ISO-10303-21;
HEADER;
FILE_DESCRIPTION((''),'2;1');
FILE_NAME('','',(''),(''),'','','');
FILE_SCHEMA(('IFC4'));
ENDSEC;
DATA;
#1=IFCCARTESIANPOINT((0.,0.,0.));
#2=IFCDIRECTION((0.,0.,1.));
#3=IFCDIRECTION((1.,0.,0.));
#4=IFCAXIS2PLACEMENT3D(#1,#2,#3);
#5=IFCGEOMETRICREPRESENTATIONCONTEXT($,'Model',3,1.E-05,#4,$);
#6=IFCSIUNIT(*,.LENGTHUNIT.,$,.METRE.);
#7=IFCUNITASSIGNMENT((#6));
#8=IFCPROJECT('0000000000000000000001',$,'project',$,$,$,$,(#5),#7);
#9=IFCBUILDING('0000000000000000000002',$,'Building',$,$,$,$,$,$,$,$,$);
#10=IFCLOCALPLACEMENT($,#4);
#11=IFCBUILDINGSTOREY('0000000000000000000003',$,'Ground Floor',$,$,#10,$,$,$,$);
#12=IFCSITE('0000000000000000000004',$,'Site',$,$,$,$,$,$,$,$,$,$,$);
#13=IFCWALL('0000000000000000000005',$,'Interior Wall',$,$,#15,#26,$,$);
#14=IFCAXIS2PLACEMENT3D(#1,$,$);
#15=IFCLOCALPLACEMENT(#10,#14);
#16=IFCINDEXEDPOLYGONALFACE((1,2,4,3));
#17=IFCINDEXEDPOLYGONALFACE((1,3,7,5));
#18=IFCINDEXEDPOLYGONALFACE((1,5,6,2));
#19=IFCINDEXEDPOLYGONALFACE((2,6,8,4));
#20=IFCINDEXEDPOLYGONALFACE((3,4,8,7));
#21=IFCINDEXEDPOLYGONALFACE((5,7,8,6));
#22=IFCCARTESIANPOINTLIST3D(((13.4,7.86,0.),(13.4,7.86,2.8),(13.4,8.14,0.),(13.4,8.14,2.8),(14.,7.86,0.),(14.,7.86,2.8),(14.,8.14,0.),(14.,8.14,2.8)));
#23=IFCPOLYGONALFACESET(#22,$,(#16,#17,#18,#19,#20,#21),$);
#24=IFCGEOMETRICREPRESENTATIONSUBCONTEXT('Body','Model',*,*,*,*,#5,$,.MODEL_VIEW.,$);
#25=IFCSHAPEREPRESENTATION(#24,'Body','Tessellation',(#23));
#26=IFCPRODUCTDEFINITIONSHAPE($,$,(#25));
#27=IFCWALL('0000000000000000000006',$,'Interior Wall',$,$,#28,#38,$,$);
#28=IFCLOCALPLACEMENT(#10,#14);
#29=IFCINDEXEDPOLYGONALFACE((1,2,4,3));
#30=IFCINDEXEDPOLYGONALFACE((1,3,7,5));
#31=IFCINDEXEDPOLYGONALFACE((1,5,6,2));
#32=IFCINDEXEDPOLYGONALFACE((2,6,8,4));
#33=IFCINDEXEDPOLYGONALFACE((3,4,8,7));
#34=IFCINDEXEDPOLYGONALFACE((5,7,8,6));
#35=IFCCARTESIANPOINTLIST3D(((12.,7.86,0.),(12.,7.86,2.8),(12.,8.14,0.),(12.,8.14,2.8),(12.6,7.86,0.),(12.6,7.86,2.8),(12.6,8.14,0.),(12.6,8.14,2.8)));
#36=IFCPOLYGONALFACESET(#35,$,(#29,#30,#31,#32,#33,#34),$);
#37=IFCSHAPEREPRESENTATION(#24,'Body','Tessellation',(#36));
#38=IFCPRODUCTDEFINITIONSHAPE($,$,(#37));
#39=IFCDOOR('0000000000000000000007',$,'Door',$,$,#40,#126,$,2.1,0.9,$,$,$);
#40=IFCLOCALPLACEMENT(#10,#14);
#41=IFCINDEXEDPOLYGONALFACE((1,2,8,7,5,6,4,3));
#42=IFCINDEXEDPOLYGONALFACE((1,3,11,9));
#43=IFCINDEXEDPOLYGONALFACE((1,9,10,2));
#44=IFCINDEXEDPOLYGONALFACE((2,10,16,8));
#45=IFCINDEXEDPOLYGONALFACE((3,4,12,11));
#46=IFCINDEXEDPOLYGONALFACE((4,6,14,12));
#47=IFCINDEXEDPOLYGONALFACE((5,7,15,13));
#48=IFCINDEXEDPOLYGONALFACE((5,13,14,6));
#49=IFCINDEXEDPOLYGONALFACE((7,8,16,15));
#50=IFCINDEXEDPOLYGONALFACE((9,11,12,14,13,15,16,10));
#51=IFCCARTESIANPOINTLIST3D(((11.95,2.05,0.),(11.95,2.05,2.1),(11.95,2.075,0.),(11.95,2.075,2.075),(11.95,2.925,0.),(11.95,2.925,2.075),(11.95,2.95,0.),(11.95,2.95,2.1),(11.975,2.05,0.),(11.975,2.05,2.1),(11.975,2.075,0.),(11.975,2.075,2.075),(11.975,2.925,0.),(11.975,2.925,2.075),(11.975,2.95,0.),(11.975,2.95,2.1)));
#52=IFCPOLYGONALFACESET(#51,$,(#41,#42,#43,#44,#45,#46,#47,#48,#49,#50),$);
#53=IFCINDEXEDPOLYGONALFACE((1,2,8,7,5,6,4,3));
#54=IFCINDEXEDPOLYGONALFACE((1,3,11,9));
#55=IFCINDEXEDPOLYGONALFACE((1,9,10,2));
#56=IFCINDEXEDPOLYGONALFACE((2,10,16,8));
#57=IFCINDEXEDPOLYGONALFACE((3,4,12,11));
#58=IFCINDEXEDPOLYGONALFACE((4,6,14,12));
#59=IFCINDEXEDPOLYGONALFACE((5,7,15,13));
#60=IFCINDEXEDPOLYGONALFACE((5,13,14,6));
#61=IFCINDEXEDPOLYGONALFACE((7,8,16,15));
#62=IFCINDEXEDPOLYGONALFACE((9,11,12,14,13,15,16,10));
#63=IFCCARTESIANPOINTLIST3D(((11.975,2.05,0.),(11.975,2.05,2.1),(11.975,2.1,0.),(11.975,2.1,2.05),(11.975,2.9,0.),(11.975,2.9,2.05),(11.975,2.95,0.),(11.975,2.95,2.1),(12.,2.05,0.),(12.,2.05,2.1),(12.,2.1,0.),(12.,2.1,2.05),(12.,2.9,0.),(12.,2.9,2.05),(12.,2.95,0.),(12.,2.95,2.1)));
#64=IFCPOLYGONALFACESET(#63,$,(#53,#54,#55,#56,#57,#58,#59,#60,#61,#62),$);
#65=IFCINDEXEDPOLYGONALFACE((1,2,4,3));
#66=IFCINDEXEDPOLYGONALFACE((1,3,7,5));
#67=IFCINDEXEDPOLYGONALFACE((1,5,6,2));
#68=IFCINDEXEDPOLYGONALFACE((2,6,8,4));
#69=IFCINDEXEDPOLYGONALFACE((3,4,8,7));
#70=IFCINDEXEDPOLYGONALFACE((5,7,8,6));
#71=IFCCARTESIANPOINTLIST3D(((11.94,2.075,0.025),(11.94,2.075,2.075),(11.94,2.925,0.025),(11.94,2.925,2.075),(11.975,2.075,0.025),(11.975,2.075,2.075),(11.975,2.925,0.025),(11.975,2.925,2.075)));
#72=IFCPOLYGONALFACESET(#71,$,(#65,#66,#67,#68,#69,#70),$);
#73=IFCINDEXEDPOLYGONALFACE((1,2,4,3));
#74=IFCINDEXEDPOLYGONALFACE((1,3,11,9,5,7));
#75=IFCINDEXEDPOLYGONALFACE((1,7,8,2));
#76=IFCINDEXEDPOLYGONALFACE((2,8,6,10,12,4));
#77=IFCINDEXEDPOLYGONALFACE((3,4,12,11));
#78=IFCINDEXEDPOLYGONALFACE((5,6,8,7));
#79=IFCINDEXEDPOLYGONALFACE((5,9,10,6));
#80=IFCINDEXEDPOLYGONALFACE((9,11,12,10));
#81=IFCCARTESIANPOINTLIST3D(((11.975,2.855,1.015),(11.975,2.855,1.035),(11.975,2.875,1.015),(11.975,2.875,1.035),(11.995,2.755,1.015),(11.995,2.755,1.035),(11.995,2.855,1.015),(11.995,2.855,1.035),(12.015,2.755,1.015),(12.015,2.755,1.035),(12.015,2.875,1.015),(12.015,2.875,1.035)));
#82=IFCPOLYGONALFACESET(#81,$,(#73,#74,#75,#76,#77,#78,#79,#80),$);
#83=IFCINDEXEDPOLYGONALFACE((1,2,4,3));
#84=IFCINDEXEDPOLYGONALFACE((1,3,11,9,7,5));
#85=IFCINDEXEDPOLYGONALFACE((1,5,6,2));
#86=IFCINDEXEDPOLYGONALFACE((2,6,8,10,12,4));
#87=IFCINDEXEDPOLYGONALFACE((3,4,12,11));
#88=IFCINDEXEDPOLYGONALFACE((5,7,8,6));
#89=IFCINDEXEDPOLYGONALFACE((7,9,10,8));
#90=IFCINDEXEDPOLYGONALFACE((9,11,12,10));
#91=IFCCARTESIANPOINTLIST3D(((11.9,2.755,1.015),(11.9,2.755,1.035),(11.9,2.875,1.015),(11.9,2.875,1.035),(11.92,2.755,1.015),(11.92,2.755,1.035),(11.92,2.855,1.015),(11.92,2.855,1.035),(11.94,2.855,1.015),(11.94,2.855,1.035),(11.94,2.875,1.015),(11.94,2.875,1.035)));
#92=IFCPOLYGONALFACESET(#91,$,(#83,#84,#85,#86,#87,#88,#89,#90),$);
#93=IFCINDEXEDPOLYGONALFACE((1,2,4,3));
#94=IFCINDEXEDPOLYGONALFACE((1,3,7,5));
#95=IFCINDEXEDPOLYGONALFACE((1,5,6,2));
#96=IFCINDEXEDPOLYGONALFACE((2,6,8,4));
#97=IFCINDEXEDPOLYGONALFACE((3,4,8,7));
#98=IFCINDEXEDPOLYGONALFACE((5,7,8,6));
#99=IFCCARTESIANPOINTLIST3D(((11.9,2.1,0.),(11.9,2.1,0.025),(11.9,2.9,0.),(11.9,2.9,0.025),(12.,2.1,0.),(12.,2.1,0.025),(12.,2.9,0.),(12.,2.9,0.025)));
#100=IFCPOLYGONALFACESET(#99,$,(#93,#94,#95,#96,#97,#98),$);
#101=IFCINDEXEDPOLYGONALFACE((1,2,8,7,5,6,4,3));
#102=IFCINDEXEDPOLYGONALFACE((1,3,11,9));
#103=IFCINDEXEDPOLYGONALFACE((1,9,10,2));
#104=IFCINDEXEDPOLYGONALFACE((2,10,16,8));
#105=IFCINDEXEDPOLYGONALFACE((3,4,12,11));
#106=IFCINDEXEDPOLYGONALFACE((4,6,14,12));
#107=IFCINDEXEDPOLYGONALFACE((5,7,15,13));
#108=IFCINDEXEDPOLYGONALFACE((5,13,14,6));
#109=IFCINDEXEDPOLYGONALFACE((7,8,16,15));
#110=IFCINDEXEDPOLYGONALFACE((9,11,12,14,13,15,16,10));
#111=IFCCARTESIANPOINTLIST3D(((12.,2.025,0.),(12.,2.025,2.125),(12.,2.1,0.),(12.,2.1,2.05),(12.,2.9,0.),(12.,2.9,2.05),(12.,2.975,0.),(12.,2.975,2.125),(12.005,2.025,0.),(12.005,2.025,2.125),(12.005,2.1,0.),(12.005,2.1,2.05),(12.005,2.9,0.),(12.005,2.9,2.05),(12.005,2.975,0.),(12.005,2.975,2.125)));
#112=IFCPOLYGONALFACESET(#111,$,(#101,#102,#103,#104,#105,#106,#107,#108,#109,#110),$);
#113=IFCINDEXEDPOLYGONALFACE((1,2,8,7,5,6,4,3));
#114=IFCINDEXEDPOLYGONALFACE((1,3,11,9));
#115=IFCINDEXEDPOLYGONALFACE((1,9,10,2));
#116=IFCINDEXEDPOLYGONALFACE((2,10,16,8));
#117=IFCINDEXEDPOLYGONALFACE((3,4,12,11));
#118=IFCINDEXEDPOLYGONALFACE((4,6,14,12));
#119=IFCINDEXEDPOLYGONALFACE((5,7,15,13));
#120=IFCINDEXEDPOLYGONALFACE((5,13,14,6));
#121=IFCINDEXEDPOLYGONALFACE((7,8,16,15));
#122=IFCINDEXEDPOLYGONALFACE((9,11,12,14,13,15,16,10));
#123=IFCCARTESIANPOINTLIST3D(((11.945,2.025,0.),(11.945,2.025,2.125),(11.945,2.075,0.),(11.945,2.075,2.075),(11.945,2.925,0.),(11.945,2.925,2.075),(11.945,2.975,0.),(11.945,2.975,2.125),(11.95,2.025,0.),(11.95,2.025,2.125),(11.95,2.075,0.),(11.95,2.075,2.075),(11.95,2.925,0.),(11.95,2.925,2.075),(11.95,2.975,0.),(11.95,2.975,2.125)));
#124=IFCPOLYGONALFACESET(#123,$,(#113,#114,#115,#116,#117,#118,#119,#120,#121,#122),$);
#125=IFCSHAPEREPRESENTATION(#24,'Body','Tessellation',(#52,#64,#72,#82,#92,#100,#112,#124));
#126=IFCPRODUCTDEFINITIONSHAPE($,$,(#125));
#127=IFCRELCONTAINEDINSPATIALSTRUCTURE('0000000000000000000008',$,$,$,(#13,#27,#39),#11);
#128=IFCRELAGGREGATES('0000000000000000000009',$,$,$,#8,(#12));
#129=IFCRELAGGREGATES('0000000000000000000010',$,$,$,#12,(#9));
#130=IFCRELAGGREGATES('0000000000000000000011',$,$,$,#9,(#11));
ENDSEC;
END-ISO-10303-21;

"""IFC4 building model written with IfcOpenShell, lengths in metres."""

from ifc_helpers import new_model, si_unit, frame, origin_with_axes, place, context, subcontext, project, spatial, line, indexed_curve, outline, extrude, element, save


model = new_model("IFC4")

# Units and contexts
model_context = context("Model", 3, precision=1e-05, world=origin_with_axes())
body_context = subcontext(model_context, "Body", "Model", "MODEL_VIEW")
ifc_project = project(units=[si_unit("LENGTHUNIT", "METRE")], contexts=[model_context])

# Site, building, storey
site = spatial("IfcSite", under=ifc_project, Name="Site")
building = spatial("IfcBuilding", under=site, Name="Building")
storey_placement = place(None, origin_with_axes())
storey = spatial("IfcBuildingStorey", under=building, at=storey_placement, Name="Ground Floor")

# Walls
for number, where, z_axis, x_axis, name in (
    (1, (14.0, 8.0, 0.0), (0.0, 0.0, 1.0), (-1.0, 0.0, 0.0), "Interior Wall"),
    (2, (12.6, 8.0, 0.0), (0.0, 0.0, 1.0), (-1.0, 0.0, 0.0), "Interior Wall"),
):
    element("IfcWall", number, at=place(storey_placement, frame(where, z_axis=z_axis, x_axis=x_axis)), inside=storey, Name=name, context=body_context, shape_type="SweptSolid", body=[
        extrude(outline(indexed_curve([(0.0, 0.0), (0.0, 0.28), (0.6, 0.28), (0.6, 0.0), (0.0, 0.0)], self_intersect=False)), frame((0.0, -0.14, 0.0), z_axis=(0.0, 0.0, 1.0), x_axis=(1.0, 0.0, 0.0)), (0.0, 0.0, 1.0), 2.8),
    ])

# Door
door_1_placement = place(storey_placement, frame((12.0, 2.05, 0.0), z_axis=(0.0, 0.0, 1.0), x_axis=(0.0, 1.0, 0.0)))
element("IfcDoor", 3, at=door_1_placement, inside=storey, Name="Door", OverallHeight=2.1, OverallWidth=0.9, context=body_context, shape_type="SweptSolid", body=[
    extrude(outline(indexed_curve([(0.0, 0.0), (0.0, 2.1), (0.9, 2.1), (0.9, 0.0), (0.875, 0.0), (0.875, 2.075), (0.025, 2.075), (0.025, 0.0)], segments=[line(1, 2, 3, 4, 5, 6, 7, 8, 1)])), frame((0.0, 0.025, 0.0), z_axis=(0.0, -1.0, 0.0), x_axis=(1.0, 0.0, 0.0)), (0.0, 0.0, -1.0), 0.025),
    extrude(outline(indexed_curve([(0.0, 0.0), (0.0, 2.1), (0.9, 2.1), (0.9, 0.0), (0.85, 0.0), (0.85, 2.05), (0.05, 2.05), (0.05, 0.0)], segments=[line(1, 2, 3, 4, 5, 6, 7, 8, 1)])), frame((0.0, 0.0, 0.0), z_axis=(0.0, -1.0, 0.0), x_axis=(1.0, 0.0, 0.0)), (0.0, 0.0, -1.0), 0.025),
    extrude(outline(indexed_curve([(0.0, 0.0), (0.85, 0.0), (0.85, 0.035), (0.0, 0.035)], segments=[line(1, 2, 3, 4, 1)])), frame((0.025, 0.025, 0.025), z_axis=(0.0, 0.0, 1.0), x_axis=(1.0, 0.0, 0.0)), (0.0, 0.0, 1.0), 2.05),
    extrude(outline(indexed_curve([(0.0, 0.0), (0.0, -0.04), (-0.12, -0.04), (-0.12, -0.02), (-0.02, -0.02), (-0.02, 0.0)], segments=[line(1, 2, 3, 4, 5, 6, 1)])), frame((0.825, 0.025, 1.015), z_axis=(0.0, 0.0, 1.0), x_axis=(1.0, 0.0, 0.0)), (0.0, 0.0, 1.0), 0.02),
    extrude(outline(indexed_curve([(0.0, 0.0), (0.0, 0.04), (-0.12, 0.04), (-0.12, 0.02), (-0.02, 0.02), (-0.02, 0.0)], segments=[line(1, 2, 3, 4, 5, 6, 1)])), frame((0.825, 0.06, 1.015), z_axis=(0.0, 0.0, 1.0), x_axis=(1.0, 0.0, 0.0)), (0.0, 0.0, 1.0), 0.02),
    extrude(outline(indexed_curve([(0.0, 0.0), (0.8, 0.0), (0.8, 0.1), (0.0, 0.1)], segments=[line(1, 2, 3, 4, 1)])), frame((0.05, 0.0, 0.0), z_axis=(0.0, 0.0, 1.0), x_axis=(1.0, 0.0, 0.0)), (0.0, 0.0, 1.0), 0.025),
    extrude(outline(indexed_curve([(0.0, 0.0), (0.0, 2.125), (0.95, 2.125), (0.95, 0.0), (0.875, 0.0), (0.875, 2.05), (0.075, 2.05), (0.075, 0.0)], segments=[line(1, 2, 3, 4, 5, 6, 7, 8, 1)])), frame((-0.025, -0.005, 0.0), z_axis=(0.0, -1.0, 0.0), x_axis=(1.0, 0.0, 0.0)), (0.0, 0.0, -1.0), 0.005),
    extrude(outline(indexed_curve([(0.0, 0.0), (0.0, 2.125), (0.95, 2.125), (0.95, 0.0), (0.9, 0.0), (0.9, 2.075), (0.05, 2.075), (0.05, 0.0)], segments=[line(1, 2, 3, 4, 5, 6, 7, 8, 1)])), frame((-0.025, 0.05, 0.0), z_axis=(0.0, -1.0, 0.0), x_axis=(1.0, 0.0, 0.0)), (0.0, 0.0, -1.0), 0.005),
])

save(model, "model.ifc")
